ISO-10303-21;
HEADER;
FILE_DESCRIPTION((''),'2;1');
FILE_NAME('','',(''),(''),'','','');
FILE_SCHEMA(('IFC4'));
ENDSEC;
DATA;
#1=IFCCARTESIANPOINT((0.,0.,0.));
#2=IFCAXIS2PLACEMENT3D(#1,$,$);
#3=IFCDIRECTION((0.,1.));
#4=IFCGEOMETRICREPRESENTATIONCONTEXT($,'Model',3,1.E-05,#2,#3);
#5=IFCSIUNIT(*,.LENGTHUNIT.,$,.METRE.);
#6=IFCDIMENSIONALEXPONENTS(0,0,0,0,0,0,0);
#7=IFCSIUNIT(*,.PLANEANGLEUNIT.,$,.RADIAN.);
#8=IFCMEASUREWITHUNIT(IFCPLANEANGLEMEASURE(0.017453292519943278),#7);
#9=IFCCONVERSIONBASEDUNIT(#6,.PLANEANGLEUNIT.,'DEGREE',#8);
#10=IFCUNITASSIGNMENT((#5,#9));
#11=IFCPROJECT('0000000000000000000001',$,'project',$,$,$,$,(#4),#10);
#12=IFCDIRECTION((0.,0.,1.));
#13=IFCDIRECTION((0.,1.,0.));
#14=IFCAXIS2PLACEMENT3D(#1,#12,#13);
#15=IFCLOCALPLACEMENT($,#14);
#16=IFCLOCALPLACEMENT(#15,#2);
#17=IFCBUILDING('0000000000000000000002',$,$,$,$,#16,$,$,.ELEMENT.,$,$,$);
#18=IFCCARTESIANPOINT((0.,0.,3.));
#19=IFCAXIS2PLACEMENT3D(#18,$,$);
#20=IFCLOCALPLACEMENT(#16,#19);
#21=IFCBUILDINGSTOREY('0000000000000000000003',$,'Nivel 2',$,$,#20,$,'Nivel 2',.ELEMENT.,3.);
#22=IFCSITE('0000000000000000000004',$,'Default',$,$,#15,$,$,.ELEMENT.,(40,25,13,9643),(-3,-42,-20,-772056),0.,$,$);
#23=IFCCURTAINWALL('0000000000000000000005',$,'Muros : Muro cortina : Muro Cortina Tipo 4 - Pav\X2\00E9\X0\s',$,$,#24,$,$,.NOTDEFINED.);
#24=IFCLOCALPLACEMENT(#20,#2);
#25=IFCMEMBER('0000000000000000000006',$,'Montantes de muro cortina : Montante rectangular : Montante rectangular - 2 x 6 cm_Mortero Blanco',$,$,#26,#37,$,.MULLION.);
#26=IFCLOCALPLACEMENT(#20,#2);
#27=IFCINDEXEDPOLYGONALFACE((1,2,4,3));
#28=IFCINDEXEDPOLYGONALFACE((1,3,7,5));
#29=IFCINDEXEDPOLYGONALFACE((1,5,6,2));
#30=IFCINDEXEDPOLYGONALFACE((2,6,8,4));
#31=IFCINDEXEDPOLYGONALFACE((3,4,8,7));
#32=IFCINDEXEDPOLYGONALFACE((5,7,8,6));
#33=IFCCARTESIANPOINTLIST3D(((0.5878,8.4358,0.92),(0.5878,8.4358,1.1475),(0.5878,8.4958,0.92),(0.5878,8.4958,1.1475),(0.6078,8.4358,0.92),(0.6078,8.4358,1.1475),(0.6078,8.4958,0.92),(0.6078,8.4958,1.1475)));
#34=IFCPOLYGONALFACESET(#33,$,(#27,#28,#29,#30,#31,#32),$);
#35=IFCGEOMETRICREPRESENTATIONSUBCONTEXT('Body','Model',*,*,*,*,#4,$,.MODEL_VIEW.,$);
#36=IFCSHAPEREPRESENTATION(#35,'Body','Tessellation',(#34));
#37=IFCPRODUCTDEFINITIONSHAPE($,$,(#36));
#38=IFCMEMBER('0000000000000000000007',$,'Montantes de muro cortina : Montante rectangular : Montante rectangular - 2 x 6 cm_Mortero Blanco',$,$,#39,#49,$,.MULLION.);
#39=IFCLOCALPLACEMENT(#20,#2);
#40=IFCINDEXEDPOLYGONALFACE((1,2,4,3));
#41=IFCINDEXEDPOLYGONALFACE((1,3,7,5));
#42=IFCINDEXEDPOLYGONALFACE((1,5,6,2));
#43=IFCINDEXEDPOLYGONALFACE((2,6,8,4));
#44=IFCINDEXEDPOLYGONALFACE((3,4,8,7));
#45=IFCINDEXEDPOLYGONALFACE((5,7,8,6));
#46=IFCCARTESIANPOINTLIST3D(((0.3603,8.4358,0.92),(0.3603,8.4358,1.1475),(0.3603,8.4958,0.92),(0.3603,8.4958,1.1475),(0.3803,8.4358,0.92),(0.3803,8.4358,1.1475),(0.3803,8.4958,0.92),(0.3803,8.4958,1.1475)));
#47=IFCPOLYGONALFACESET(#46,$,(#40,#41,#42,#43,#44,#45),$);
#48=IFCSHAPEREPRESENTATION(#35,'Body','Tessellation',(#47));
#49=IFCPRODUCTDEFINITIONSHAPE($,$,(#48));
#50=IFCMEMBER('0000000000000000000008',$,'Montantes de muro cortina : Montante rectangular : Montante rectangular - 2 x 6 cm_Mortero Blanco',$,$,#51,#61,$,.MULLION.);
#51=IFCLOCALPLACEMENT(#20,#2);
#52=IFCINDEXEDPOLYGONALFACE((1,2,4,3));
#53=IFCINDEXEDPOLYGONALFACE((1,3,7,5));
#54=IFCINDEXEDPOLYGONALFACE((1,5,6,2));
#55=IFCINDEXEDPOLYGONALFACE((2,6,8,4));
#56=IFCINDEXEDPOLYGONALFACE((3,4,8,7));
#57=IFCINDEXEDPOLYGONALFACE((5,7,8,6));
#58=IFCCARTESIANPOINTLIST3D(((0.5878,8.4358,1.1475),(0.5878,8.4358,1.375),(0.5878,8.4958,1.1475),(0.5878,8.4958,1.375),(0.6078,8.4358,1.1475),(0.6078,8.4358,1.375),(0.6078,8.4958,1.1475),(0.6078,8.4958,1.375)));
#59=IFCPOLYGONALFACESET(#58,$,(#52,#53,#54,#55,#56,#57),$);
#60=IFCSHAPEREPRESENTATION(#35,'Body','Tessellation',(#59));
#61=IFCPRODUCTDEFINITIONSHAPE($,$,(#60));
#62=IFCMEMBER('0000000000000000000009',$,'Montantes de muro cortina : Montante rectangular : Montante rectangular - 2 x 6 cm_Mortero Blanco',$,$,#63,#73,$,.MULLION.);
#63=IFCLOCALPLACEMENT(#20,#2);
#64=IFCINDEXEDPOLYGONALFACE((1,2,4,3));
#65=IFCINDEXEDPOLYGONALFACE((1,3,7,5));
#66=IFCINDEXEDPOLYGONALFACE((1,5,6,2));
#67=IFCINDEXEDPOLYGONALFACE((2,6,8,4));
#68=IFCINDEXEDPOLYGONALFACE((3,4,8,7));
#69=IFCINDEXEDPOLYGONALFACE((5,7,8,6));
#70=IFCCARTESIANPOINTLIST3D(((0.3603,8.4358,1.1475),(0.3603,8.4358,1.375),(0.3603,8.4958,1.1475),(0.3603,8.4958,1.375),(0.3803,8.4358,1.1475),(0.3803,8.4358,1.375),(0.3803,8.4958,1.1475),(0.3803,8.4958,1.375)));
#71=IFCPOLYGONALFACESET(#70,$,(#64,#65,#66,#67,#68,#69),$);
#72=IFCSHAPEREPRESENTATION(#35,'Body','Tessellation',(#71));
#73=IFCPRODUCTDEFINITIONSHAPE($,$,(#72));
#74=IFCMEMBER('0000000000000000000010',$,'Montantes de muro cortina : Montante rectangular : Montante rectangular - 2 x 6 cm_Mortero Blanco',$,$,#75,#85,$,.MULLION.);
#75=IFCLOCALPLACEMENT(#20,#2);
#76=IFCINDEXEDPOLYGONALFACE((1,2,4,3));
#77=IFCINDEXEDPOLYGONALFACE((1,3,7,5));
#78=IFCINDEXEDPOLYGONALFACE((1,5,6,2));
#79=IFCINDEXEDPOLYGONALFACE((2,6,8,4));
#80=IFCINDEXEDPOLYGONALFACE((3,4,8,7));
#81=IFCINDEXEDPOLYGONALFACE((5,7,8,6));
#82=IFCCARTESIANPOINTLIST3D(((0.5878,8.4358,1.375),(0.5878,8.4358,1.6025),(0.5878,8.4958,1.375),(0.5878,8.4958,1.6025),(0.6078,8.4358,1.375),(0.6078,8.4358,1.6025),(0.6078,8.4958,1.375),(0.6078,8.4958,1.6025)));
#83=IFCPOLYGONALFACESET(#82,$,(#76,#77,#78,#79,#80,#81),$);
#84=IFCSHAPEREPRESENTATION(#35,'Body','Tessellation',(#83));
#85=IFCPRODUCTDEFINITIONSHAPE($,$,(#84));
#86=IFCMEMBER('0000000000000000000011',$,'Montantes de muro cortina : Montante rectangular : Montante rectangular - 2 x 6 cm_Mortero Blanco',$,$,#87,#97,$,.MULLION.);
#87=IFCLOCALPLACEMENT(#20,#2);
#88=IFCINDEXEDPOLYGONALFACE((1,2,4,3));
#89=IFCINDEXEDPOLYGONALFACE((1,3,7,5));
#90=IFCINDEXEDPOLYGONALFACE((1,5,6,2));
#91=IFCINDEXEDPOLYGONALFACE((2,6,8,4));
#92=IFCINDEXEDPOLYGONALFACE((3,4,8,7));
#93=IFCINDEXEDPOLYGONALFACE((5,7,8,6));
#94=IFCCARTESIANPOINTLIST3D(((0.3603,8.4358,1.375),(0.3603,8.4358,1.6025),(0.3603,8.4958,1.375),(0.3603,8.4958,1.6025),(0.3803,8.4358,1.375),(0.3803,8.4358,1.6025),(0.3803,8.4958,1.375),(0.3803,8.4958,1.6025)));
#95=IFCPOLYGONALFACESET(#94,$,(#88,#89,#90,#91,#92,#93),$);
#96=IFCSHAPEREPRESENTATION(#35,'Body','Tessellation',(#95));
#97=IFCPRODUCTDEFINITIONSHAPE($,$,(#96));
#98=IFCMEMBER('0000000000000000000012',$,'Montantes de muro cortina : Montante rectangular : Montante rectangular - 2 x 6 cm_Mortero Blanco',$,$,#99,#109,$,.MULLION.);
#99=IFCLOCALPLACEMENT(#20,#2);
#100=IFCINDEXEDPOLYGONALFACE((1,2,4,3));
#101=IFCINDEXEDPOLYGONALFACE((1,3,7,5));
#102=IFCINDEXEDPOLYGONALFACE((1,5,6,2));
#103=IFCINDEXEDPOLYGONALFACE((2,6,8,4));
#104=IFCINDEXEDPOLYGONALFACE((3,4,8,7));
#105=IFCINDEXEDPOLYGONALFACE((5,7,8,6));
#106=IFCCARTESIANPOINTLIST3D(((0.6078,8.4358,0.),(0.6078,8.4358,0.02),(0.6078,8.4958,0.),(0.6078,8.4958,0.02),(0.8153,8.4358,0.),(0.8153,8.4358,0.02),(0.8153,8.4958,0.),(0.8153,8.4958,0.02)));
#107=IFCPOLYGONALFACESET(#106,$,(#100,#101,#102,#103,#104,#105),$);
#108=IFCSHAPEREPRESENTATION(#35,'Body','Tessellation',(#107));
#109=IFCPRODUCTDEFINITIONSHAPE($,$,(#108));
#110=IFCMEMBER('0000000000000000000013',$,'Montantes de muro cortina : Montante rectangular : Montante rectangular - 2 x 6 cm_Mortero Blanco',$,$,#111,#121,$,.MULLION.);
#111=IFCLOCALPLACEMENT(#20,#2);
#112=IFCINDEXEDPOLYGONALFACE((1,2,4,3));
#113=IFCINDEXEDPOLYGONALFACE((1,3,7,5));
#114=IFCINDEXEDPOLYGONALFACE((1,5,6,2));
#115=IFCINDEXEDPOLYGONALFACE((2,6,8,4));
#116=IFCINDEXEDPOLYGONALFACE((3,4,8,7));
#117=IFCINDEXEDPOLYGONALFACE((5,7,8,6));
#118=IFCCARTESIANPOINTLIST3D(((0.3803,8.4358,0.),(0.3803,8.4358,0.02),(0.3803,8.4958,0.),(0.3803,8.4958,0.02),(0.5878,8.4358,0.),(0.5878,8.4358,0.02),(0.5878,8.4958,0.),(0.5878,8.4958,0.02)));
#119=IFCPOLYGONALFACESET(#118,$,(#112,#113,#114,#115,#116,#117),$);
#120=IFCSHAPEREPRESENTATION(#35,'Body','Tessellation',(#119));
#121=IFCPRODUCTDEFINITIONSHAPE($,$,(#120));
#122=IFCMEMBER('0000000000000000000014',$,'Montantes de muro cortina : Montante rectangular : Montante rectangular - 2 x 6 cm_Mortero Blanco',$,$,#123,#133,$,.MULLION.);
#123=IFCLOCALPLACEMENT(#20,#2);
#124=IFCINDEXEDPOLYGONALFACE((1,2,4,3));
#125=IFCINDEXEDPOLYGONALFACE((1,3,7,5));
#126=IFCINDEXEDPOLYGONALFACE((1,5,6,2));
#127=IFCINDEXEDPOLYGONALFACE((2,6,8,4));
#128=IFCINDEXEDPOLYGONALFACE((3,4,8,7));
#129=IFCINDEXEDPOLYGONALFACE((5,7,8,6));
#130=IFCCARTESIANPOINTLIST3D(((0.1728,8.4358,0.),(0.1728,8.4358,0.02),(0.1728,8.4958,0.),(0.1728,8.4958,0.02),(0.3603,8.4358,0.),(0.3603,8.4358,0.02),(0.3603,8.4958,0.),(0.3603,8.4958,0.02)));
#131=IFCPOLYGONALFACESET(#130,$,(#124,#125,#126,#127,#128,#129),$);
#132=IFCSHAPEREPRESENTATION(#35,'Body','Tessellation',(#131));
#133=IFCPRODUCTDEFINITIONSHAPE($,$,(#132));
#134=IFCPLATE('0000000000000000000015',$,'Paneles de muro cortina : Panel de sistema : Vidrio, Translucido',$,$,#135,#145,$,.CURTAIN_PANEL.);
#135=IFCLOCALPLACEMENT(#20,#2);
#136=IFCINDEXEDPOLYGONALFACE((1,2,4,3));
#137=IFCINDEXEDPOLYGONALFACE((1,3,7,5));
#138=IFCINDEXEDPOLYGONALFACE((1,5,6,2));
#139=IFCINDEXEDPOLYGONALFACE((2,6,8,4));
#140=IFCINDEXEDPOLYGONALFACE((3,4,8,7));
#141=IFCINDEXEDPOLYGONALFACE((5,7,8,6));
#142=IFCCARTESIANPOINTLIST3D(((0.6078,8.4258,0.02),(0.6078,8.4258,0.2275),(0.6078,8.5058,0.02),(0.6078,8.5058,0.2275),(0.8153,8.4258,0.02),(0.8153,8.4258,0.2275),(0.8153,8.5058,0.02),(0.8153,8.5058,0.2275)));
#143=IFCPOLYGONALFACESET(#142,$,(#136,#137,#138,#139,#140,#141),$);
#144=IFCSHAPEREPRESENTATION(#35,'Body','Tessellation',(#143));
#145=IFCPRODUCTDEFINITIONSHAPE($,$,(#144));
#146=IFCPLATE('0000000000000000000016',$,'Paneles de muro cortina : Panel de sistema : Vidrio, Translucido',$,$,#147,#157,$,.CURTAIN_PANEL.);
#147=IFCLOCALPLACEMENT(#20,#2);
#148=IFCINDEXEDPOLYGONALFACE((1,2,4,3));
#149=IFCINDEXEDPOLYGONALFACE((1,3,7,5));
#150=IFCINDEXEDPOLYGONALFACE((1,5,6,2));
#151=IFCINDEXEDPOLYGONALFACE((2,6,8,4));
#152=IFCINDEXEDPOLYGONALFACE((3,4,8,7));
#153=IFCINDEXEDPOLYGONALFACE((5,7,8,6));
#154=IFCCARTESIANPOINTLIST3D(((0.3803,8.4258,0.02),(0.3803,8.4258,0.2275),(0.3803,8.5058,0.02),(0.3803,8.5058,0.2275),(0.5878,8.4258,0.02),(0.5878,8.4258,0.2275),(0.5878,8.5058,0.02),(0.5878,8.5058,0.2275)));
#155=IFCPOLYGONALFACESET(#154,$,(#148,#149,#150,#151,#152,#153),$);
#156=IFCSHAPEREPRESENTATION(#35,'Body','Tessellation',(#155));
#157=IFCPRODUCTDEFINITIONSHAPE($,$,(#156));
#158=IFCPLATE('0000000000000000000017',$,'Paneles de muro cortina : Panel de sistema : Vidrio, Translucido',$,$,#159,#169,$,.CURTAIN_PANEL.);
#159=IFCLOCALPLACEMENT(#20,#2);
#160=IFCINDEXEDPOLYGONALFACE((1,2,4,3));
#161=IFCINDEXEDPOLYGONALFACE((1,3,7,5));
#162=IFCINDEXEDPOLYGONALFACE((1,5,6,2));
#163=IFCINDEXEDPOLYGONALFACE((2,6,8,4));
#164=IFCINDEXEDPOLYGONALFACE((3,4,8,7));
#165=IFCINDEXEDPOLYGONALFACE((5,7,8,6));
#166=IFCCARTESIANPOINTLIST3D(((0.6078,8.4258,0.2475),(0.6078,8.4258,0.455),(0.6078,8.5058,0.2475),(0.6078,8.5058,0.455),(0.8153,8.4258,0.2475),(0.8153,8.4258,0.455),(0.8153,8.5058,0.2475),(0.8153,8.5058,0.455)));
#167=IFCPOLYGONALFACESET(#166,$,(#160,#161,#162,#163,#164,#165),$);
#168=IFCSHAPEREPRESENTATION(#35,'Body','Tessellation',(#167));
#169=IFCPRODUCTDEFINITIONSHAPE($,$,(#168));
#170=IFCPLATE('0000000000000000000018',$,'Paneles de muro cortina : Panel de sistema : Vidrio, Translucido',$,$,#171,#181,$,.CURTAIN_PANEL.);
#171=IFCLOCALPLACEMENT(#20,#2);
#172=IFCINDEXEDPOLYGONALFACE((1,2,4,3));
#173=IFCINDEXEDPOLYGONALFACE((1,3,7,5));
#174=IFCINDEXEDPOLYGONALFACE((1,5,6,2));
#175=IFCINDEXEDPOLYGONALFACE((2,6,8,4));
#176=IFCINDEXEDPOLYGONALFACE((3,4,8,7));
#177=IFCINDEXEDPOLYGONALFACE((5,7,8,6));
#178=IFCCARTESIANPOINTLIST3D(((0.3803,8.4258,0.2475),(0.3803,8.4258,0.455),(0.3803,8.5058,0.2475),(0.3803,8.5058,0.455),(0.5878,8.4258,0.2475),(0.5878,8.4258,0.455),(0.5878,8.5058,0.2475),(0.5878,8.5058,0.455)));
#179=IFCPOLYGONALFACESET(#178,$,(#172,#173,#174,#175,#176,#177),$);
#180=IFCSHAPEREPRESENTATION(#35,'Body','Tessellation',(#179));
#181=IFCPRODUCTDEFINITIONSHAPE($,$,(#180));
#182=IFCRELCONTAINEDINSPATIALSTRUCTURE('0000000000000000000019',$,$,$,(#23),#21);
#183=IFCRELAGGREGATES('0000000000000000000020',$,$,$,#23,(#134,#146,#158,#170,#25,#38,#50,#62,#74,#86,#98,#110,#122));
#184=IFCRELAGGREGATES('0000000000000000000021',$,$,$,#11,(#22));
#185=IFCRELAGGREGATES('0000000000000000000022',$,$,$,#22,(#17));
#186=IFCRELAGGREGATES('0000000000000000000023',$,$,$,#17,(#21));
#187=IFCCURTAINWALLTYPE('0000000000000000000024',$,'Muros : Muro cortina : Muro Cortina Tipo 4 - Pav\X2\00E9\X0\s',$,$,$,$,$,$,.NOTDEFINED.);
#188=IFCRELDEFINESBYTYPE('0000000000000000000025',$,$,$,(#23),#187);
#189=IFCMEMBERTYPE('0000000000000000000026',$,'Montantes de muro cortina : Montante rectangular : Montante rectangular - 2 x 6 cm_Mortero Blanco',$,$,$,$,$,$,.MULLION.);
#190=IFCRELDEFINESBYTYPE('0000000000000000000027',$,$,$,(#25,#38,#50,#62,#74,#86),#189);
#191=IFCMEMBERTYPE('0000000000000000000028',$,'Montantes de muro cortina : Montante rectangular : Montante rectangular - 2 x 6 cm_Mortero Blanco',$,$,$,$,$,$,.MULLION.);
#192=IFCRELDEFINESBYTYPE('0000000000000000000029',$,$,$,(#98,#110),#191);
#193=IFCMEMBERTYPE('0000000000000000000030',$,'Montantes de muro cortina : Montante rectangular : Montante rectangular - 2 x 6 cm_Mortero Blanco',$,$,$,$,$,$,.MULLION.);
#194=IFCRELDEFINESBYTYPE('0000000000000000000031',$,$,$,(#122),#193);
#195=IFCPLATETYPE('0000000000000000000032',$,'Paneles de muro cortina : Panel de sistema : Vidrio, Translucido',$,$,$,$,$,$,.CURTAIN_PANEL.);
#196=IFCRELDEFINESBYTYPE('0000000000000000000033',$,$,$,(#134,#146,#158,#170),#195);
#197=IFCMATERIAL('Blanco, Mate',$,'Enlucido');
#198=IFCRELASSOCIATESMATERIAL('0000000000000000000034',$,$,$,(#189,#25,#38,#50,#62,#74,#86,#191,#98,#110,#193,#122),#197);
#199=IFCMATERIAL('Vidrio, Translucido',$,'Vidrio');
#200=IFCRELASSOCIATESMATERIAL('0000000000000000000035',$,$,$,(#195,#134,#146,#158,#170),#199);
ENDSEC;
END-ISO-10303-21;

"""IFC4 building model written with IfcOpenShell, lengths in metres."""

from ifc_helpers import new_model, entity, si_unit, converted_unit, direction, frame, origin, place, context, subcontext, project, spatial, indexed_curve, outline, extrude, source, transform, mapped, material, type_object, type_shapes, element, aggregate, save


model = new_model("IFC4")

# Units and contexts
model_context = context("Model", 3, precision=1e-05, world=origin(), true_north=direction((0.0, 1.0)))
body_context = subcontext(model_context, "Body", "Model", "MODEL_VIEW")
ifc_project = project(units=[si_unit("LENGTHUNIT", "METRE"), converted_unit("PLANEANGLEUNIT", "DEGREE", entity("IfcPlaneAngleMeasure", 0.017453292519943278), si_unit("PLANEANGLEUNIT", "RADIAN"), dimensions=[0, 0, 0, 0, 0, 0, 0])], contexts=[model_context])

# Site, building, storey
site_placement = place(None, frame((0.0, 0.0, 0.0), z_axis=(0.0, 0.0, 1.0), x_axis=(0.0, 1.0, 0.0)))
site = spatial("IfcSite", under=ifc_project, at=site_placement, Name="Default", CompositionType="ELEMENT", RefLatitude=(40, 25, 13, 9643), RefLongitude=(-3, -42, -20, -772056), RefElevation=0.0)
building_placement = place(site_placement, origin())
building = spatial("IfcBuilding", under=site, at=building_placement, CompositionType="ELEMENT")
storey_placement = place(building_placement, frame((0.0, 0.0, 3.0)))
storey = spatial("IfcBuildingStorey", under=building, at=storey_placement, Name="Nivel 2", LongName="Nivel 2", CompositionType="ELEMENT", Elevation=3.0)

# Curtain wall, members, plates
curtain_wall_type = type_object("IfcCurtainWallType", Name="Muros : Muro cortina : Muro Cortina Tipo 4 - Pavés", PredefinedType="NOTDEFINED")
curtain_wall_placement = place(storey_placement, frame((0.0, 0.0, -3.0)))
curtain_wall = element("IfcCurtainWall", 1, at=curtain_wall_placement, inside=storey, type_object=curtain_wall_type, Name="Muros : Muro cortina : Muro Cortina Tipo 4 - Pavés", PredefinedType="NOTDEFINED")
ifc_material_1 = material(Name="Blanco, Mate", Category="Enlucido")
member_type_1 = type_object("IfcMemberType", Name="Montantes de muro cortina : Montante rectangular : Montante rectangular - 2 x 6 cm_Mortero Blanco", PredefinedType="MULLION", material=ifc_material_1)
shared_shape_1 = source(origin(), body_context, "Body", "SweptSolid", [
    extrude(outline(indexed_curve([(-0.01, -0.03), (0.01, -0.03), (0.01, 0.03), (-0.01, 0.03), (-0.01, -0.03)], self_intersect=False)), frame((0.0, 0.0, -0.2275), z_axis=(0.0, 0.0, 1.0), x_axis=(-1.0, 0.0, 0.0)), (0.0, 0.0, 1.0), 0.2275),
])
type_shapes(member_type_1, [shared_shape_1])
member_1_placement = place(curtain_wall_placement, frame((0.5978, 8.4658, 3.92), z_axis=(0.0, 0.0, -1.0), x_axis=(-1.0, 0.0, 0.0)))
member_1 = element("IfcMember", 2, at=member_1_placement, type_object=member_type_1, material=ifc_material_1, Name="Montantes de muro cortina : Montante rectangular : Montante rectangular - 2 x 6 cm_Mortero Blanco", PredefinedType="MULLION", context=body_context, shape_type="MappedRepresentation", body=[
    mapped(shared_shape_1, transform((0.0, 0.0, 0.0), scale=1.0)),
])
member_2_placement = place(curtain_wall_placement, frame((0.3703, 8.4658, 3.92), z_axis=(0.0, 0.0, -1.0), x_axis=(-1.0, 0.0, 0.0)))
member_2 = element("IfcMember", 3, at=member_2_placement, type_object=member_type_1, material=ifc_material_1, Name="Montantes de muro cortina : Montante rectangular : Montante rectangular - 2 x 6 cm_Mortero Blanco", PredefinedType="MULLION", context=body_context, shape_type="MappedRepresentation", body=[
    mapped(shared_shape_1, transform((0.0, 0.0, 0.0), scale=1.0)),
])
member_3_placement = place(curtain_wall_placement, frame((0.5978, 8.4658, 4.1475), z_axis=(0.0, 0.0, -1.0), x_axis=(-1.0, 0.0, 0.0)))
member_3 = element("IfcMember", 4, at=member_3_placement, type_object=member_type_1, material=ifc_material_1, Name="Montantes de muro cortina : Montante rectangular : Montante rectangular - 2 x 6 cm_Mortero Blanco", PredefinedType="MULLION", context=body_context, shape_type="MappedRepresentation", body=[
    mapped(shared_shape_1, transform((0.0, 0.0, 0.0), scale=1.0)),
])
member_4_placement = place(curtain_wall_placement, frame((0.3703, 8.4658, 4.1475), z_axis=(0.0, 0.0, -1.0), x_axis=(-1.0, 0.0, 0.0)))
member_4 = element("IfcMember", 5, at=member_4_placement, type_object=member_type_1, material=ifc_material_1, Name="Montantes de muro cortina : Montante rectangular : Montante rectangular - 2 x 6 cm_Mortero Blanco", PredefinedType="MULLION", context=body_context, shape_type="MappedRepresentation", body=[
    mapped(shared_shape_1, transform((0.0, 0.0, 0.0), scale=1.0)),
])
member_5_placement = place(curtain_wall_placement, frame((0.5978, 8.4658, 4.375), z_axis=(0.0, 0.0, -1.0), x_axis=(-1.0, 0.0, 0.0)))
member_5 = element("IfcMember", 6, at=member_5_placement, type_object=member_type_1, material=ifc_material_1, Name="Montantes de muro cortina : Montante rectangular : Montante rectangular - 2 x 6 cm_Mortero Blanco", PredefinedType="MULLION", context=body_context, shape_type="MappedRepresentation", body=[
    mapped(shared_shape_1, transform((0.0, 0.0, 0.0), scale=1.0)),
])
member_6_placement = place(curtain_wall_placement, frame((0.3703, 8.4658, 4.375), z_axis=(0.0, 0.0, -1.0), x_axis=(-1.0, 0.0, 0.0)))
member_6 = element("IfcMember", 7, at=member_6_placement, type_object=member_type_1, material=ifc_material_1, Name="Montantes de muro cortina : Montante rectangular : Montante rectangular - 2 x 6 cm_Mortero Blanco", PredefinedType="MULLION", context=body_context, shape_type="MappedRepresentation", body=[
    mapped(shared_shape_1, transform((0.0, 0.0, 0.0), scale=1.0)),
])
member_type_2 = type_object("IfcMemberType", Name="Montantes de muro cortina : Montante rectangular : Montante rectangular - 2 x 6 cm_Mortero Blanco", PredefinedType="MULLION", material=ifc_material_1)
shared_shape_2 = source(origin(), body_context, "Body", "SweptSolid", [
    extrude(outline(indexed_curve([(-0.01, -0.03), (0.01, -0.03), (0.01, 0.03), (-0.01, 0.03), (-0.01, -0.03)], self_intersect=False)), frame((-0.01, 0.0, -0.2075), z_axis=(0.0, 0.0, 1.0), x_axis=(-1.0, 0.0, 0.0)), (0.0, 0.0, 1.0), 0.2075),
])
type_shapes(member_type_2, [shared_shape_2])
member_7_placement = place(curtain_wall_placement, frame((0.8153, 8.4658, 3.0), z_axis=(1.0, 0.0, 0.0), x_axis=(0.0, 0.0, -1.0)))
member_7 = element("IfcMember", 8, at=member_7_placement, type_object=member_type_2, material=ifc_material_1, Name="Montantes de muro cortina : Montante rectangular : Montante rectangular - 2 x 6 cm_Mortero Blanco", PredefinedType="MULLION", context=body_context, shape_type="MappedRepresentation", body=[
    mapped(shared_shape_2, transform((0.0, 0.0, 0.0), scale=1.0)),
])
member_8_placement = place(curtain_wall_placement, frame((0.5878, 8.4658, 3.0), z_axis=(1.0, 0.0, 0.0), x_axis=(0.0, 0.0, -1.0)))
member_8 = element("IfcMember", 9, at=member_8_placement, type_object=member_type_2, material=ifc_material_1, Name="Montantes de muro cortina : Montante rectangular : Montante rectangular - 2 x 6 cm_Mortero Blanco", PredefinedType="MULLION", context=body_context, shape_type="MappedRepresentation", body=[
    mapped(shared_shape_2, transform((0.0, 0.0, 0.0), scale=1.0)),
])
member_type_3 = type_object("IfcMemberType", Name="Montantes de muro cortina : Montante rectangular : Montante rectangular - 2 x 6 cm_Mortero Blanco", PredefinedType="MULLION", material=ifc_material_1)
shared_shape_3 = source(origin(), body_context, "Body", "SweptSolid", [
    extrude(outline(indexed_curve([(-0.01, -0.03), (0.01, -0.03), (0.01, 0.03), (-0.01, 0.03), (-0.01, -0.03)], self_intersect=False)), frame((-0.01, 0.0, -0.1875), z_axis=(0.0, 0.0, 1.0), x_axis=(-1.0, 0.0, 0.0)), (0.0, 0.0, 1.0), 0.1875),
])
type_shapes(member_type_3, [shared_shape_3])
member_9_placement = place(curtain_wall_placement, frame((0.3603, 8.4658, 3.0), z_axis=(1.0, 0.0, 0.0), x_axis=(0.0, 0.0, -1.0)))
member_9 = element("IfcMember", 10, at=member_9_placement, type_object=member_type_3, material=ifc_material_1, Name="Montantes de muro cortina : Montante rectangular : Montante rectangular - 2 x 6 cm_Mortero Blanco", PredefinedType="MULLION", context=body_context, shape_type="MappedRepresentation", body=[
    mapped(shared_shape_3, transform((0.0, 0.0, 0.0), scale=1.0)),
])
ifc_material_2 = material(Name="Vidrio, Translucido", Category="Vidrio")
plate_type = type_object("IfcPlateType", Name="Paneles de muro cortina : Panel de sistema : Vidrio, Translucido", PredefinedType="CURTAIN_PANEL", material=ifc_material_2)
shared_shape_4 = source(origin(), body_context, "Body", "SweptSolid", [
    extrude(outline(indexed_curve([(-0.04, -0.1038), (0.04, -0.1038), (0.04, 0.1038), (-0.04, 0.1038), (-0.04, -0.1038)], self_intersect=False)), frame((0.0, 0.0, 0.0), z_axis=(0.0, 0.0, 1.0), x_axis=(0.0, 1.0, 0.0)), (0.0, 0.0, 1.0), 0.2075),
])
type_shapes(plate_type, [shared_shape_4])
plate_1_placement = place(curtain_wall_placement, frame((0.7115, 8.4658, 3.02), z_axis=(0.0, 0.0, 1.0), x_axis=(-1.0, 0.0, 0.0)))
plate_1 = element("IfcPlate", 11, at=plate_1_placement, type_object=plate_type, material=ifc_material_2, Name="Paneles de muro cortina : Panel de sistema : Vidrio, Translucido", PredefinedType="CURTAIN_PANEL", context=body_context, shape_type="MappedRepresentation", body=[
    mapped(shared_shape_4, transform((0.0, 0.0, 0.0), scale=1.0)),
])
plate_2_placement = place(curtain_wall_placement, frame((0.484, 8.4658, 3.02), z_axis=(0.0, 0.0, 1.0), x_axis=(-1.0, 0.0, 0.0)))
plate_2 = element("IfcPlate", 12, at=plate_2_placement, type_object=plate_type, material=ifc_material_2, Name="Paneles de muro cortina : Panel de sistema : Vidrio, Translucido", PredefinedType="CURTAIN_PANEL", context=body_context, shape_type="MappedRepresentation", body=[
    mapped(shared_shape_4, transform((0.0, 0.0, 0.0), scale=1.0)),
])
plate_3_placement = place(curtain_wall_placement, frame((0.7115, 8.4658, 3.2475), z_axis=(0.0, 0.0, 1.0), x_axis=(-1.0, 0.0, 0.0)))
plate_3 = element("IfcPlate", 13, at=plate_3_placement, type_object=plate_type, material=ifc_material_2, Name="Paneles de muro cortina : Panel de sistema : Vidrio, Translucido", PredefinedType="CURTAIN_PANEL", context=body_context, shape_type="MappedRepresentation", body=[
    mapped(shared_shape_4, transform((0.0, 0.0, 0.0), scale=1.0)),
])
plate_4_placement = place(curtain_wall_placement, frame((0.484, 8.4658, 3.2475), z_axis=(0.0, 0.0, 1.0), x_axis=(-1.0, 0.0, 0.0)))
plate_4 = element("IfcPlate", 14, at=plate_4_placement, type_object=plate_type, material=ifc_material_2, Name="Paneles de muro cortina : Panel de sistema : Vidrio, Translucido", PredefinedType="CURTAIN_PANEL", context=body_context, shape_type="MappedRepresentation", body=[
    mapped(shared_shape_4, transform((0.0, 0.0, 0.0), scale=1.0)),
])
aggregate(curtain_wall, [plate_1, plate_2, plate_3, plate_4, member_1, member_2, member_3, member_4, member_5, member_6, member_7, member_8, member_9])

save(model, "model.ifc")
